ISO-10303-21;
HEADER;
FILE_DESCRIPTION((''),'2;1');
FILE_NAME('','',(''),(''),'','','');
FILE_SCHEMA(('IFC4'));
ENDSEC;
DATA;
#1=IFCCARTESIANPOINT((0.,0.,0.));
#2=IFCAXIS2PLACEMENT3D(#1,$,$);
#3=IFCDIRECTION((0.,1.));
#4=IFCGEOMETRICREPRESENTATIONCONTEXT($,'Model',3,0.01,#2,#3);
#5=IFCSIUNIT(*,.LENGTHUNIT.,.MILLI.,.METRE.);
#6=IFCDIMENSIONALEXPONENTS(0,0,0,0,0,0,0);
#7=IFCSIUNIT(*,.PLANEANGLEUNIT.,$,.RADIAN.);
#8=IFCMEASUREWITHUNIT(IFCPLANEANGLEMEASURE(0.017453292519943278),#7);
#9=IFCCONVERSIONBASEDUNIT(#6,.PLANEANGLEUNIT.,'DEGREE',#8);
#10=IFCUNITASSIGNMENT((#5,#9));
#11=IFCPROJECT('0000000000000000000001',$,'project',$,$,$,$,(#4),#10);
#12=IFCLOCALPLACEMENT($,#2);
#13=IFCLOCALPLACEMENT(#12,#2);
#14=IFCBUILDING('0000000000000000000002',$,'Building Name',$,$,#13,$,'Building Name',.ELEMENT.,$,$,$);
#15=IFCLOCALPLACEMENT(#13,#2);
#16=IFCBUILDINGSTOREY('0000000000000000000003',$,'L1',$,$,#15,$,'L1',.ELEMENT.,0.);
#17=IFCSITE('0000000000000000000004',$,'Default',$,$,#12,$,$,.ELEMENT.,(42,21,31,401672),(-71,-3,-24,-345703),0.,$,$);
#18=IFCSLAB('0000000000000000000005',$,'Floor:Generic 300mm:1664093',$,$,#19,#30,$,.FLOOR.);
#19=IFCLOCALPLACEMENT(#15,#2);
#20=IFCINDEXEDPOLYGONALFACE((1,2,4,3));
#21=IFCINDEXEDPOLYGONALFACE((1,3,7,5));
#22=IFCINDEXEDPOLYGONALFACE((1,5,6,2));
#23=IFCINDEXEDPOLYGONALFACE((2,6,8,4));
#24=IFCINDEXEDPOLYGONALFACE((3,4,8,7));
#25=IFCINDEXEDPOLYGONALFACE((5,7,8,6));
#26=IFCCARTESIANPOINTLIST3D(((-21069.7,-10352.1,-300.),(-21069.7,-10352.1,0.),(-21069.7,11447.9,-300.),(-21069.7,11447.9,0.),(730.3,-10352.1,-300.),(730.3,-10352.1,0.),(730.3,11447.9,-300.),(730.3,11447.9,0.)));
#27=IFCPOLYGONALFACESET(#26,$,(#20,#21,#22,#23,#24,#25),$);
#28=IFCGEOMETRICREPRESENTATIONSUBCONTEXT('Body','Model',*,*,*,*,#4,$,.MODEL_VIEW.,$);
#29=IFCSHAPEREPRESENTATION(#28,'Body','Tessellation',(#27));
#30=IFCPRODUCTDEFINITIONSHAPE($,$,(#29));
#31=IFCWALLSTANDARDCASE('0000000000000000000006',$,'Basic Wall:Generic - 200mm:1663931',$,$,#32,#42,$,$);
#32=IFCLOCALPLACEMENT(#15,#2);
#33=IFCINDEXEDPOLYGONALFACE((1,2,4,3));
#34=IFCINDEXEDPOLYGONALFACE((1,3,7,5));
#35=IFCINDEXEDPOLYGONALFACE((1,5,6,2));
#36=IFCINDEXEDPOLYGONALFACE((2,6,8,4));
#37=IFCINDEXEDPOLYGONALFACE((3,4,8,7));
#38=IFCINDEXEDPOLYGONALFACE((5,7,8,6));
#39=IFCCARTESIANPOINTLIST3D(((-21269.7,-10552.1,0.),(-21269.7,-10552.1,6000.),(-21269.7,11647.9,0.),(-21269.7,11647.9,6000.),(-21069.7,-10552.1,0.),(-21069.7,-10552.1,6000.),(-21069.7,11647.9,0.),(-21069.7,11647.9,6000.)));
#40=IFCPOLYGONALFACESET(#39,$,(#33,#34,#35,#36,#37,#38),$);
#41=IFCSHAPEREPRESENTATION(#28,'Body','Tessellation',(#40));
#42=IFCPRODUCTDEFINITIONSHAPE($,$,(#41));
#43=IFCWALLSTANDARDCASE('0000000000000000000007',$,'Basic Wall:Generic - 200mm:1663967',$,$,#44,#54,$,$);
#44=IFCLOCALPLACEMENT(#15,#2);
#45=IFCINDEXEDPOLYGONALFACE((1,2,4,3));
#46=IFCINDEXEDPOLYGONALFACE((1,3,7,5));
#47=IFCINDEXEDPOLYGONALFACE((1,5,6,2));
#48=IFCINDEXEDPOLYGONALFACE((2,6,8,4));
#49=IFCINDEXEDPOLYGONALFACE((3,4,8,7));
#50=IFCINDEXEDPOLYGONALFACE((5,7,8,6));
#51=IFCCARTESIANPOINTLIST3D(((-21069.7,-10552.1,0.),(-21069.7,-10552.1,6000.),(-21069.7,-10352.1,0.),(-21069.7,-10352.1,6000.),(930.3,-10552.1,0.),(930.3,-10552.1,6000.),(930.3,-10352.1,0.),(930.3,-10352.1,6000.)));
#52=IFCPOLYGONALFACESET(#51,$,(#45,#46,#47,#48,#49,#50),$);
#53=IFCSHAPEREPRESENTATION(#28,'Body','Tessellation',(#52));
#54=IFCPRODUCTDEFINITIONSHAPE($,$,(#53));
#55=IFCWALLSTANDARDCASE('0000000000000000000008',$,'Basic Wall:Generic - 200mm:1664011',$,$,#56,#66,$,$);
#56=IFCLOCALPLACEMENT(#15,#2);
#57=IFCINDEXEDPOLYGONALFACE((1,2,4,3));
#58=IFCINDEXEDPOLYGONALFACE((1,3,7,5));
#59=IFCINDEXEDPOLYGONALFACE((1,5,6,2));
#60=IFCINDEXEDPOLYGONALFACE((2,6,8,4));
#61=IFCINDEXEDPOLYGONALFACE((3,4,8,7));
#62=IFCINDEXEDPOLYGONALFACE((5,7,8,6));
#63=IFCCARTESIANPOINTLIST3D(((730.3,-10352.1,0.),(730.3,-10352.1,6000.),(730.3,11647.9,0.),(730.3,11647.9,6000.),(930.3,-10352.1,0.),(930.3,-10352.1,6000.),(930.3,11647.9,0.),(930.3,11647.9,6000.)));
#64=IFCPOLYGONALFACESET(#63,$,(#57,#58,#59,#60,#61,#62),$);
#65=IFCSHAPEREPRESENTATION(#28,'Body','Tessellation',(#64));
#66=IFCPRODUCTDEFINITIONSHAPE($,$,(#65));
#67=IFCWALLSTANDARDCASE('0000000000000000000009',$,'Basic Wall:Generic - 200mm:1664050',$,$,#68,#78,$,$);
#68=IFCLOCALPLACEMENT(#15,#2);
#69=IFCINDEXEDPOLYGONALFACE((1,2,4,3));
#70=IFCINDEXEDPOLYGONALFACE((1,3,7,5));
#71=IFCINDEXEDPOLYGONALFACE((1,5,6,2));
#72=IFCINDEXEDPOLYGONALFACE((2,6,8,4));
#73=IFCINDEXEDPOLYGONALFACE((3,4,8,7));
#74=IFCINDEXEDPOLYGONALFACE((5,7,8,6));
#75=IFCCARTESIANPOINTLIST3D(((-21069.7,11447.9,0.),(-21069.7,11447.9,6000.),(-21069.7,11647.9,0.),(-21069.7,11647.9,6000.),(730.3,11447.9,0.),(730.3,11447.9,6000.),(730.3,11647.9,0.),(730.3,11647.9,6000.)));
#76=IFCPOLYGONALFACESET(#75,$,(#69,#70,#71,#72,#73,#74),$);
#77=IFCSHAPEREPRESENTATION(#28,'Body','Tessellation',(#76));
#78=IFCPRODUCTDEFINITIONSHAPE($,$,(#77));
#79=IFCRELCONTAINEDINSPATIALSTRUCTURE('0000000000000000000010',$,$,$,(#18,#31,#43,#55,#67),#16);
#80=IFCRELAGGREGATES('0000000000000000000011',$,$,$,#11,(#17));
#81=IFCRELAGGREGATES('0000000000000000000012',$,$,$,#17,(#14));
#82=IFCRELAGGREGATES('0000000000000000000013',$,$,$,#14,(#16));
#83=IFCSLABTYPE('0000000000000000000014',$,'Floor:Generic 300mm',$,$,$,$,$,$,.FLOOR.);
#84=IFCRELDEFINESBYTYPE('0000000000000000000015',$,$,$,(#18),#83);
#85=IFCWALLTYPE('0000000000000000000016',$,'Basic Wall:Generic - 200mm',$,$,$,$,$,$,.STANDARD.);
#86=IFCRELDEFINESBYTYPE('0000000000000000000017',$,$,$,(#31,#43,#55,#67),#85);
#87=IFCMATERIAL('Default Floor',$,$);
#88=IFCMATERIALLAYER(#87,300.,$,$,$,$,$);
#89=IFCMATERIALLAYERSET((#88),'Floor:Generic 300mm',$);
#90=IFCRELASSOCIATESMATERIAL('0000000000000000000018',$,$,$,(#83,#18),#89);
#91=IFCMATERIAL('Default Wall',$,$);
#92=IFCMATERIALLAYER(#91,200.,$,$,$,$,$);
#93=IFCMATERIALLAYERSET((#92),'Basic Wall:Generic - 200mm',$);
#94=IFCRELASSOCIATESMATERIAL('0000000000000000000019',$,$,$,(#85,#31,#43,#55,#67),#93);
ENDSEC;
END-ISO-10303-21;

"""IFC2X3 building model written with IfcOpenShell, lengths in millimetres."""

from ifc_helpers import new_model, entity, si_unit, converted_unit, direction, frame, frame_2d, origin, origin_2d_with_axis, place, context, subcontext, project, spatial, rectangle, extrude, material, layer, layer_set, layer_usage, type_object, element, save


model = new_model("IFC2X3")

# Units and contexts
model_context = context("Model", 3, precision=0.01, world=origin(), true_north=direction((0.0, 1.0)))
body_context = subcontext(model_context, "Body", "Model", "MODEL_VIEW")
ifc_project = project(units=[si_unit("LENGTHUNIT", "METRE", prefix="MILLI"), converted_unit("PLANEANGLEUNIT", "DEGREE", entity("IfcPlaneAngleMeasure", 0.017453292519943278), si_unit("PLANEANGLEUNIT", "RADIAN"), dimensions=[0, 0, 0, 0, 0, 0, 0])], contexts=[model_context])

# Site, building, storey
site_placement = place(None, origin())
site = spatial("IfcSite", under=ifc_project, at=site_placement, Name="Default", CompositionType="ELEMENT", RefLatitude=(42, 21, 31, 401672), RefLongitude=(-71, -3, -24, -345703), RefElevation=0.0)
building_placement = place(site_placement, origin())
building = spatial("IfcBuilding", under=site, at=building_placement, Name="Building Name", LongName="Building Name", CompositionType="ELEMENT")
storey_placement = place(building_placement, origin())
storey = spatial("IfcBuildingStorey", under=building, at=storey_placement, Name="L1", LongName="L1", CompositionType="ELEMENT", Elevation=0.0)

# Slab
ifc_material_1 = material(Name="Default Floor")
ifc_layer_1 = layer(ifc_material_1, 300.0)
ifc_layer_set_1 = layer_set([ifc_layer_1], Name="Floor:Generic 300mm")
ifc_layer_usage_1 = layer_usage(ifc_layer_set_1, "AXIS3", "POSITIVE", 0.0)
slab_type = type_object("IfcSlabType", Name="Floor:Generic 300mm", PredefinedType="FLOOR", material=ifc_layer_set_1)
slab_placement = place(storey_placement, origin())
element("IfcSlab", 1, at=slab_placement, inside=storey, type_object=slab_type, material=ifc_layer_usage_1, Name="Floor:Generic 300mm:1664093", PredefinedType="FLOOR", context=body_context, shape_type="SweptSolid", body=[
    extrude(rectangle(XDim=21800.0, YDim=21800.0, at=origin_2d_with_axis()), frame((-10169.7, 547.9, 0.0), z_axis=(0.0, 0.0, -1.0), x_axis=(0.0, 1.0, 0.0)), (0.0, 0.0, 1.0), 300.0),
])

# Walls
ifc_material_2 = material(Name="Default Wall")
ifc_layer_2 = layer(ifc_material_2, 200.0)
ifc_layer_set_2 = layer_set([ifc_layer_2], Name="Basic Wall:Generic - 200mm")
ifc_layer_usage_2 = layer_usage(ifc_layer_set_2, "AXIS2", "NEGATIVE", 100.0)
wall_type = type_object("IfcWallType", Name="Basic Wall:Generic - 200mm", PredefinedType="STANDARD", material=ifc_layer_set_2)
wall_1_placement = place(storey_placement, frame((-21169.7, 11647.9, 0.0), z_axis=(0.0, 0.0, 1.0), x_axis=(0.0, -1.0, 0.0)))
element("IfcWallStandardCase", 2, at=wall_1_placement, inside=storey, type_object=wall_type, material=ifc_layer_usage_2, Name="Basic Wall:Generic - 200mm:1663931", context=body_context, shape_type="SweptSolid", body=[
    extrude(rectangle(XDim=22200.0, YDim=200.0, at=frame_2d((11100.0, 0.0), x_axis=(-1.0, 0.0))), origin(), (0.0, 0.0, 1.0), 6000.0),
])
ifc_layer_usage_3 = layer_usage(ifc_layer_set_2, "AXIS2", "NEGATIVE", 100.0)
wall_2_placement = place(storey_placement, frame((-21069.7, -10452.1, 0.0)))
element("IfcWallStandardCase", 3, at=wall_2_placement, inside=storey, type_object=wall_type, material=ifc_layer_usage_3, Name="Basic Wall:Generic - 200mm:1663967", context=body_context, shape_type="SweptSolid", body=[
    extrude(rectangle(XDim=22000.0, YDim=200.0, at=frame_2d((11000.0, 0.0), x_axis=(-1.0, 0.0))), origin(), (0.0, 0.0, 1.0), 6000.0),
])
ifc_layer_usage_4 = layer_usage(ifc_layer_set_2, "AXIS2", "NEGATIVE", 100.0)
wall_3_placement = place(storey_placement, frame((830.3, -10352.1, 0.0), z_axis=(0.0, 0.0, 1.0), x_axis=(0.0, 1.0, 0.0)))
element("IfcWallStandardCase", 4, at=wall_3_placement, inside=storey, type_object=wall_type, material=ifc_layer_usage_4, Name="Basic Wall:Generic - 200mm:1664011", context=body_context, shape_type="SweptSolid", body=[
    extrude(rectangle(XDim=22000.0, YDim=200.0, at=frame_2d((11000.0, 0.0), x_axis=(-1.0, 0.0))), origin(), (0.0, 0.0, 1.0), 6000.0),
])
ifc_layer_usage_5 = layer_usage(ifc_layer_set_2, "AXIS2", "NEGATIVE", 100.0)
wall_4_placement = place(storey_placement, frame((730.3, 11547.9, 0.0), z_axis=(0.0, 0.0, 1.0), x_axis=(-1.0, 0.0, 0.0)))
element("IfcWallStandardCase", 5, at=wall_4_placement, inside=storey, type_object=wall_type, material=ifc_layer_usage_5, Name="Basic Wall:Generic - 200mm:1664050", context=body_context, shape_type="SweptSolid", body=[
    extrude(rectangle(XDim=21800.0, YDim=200.0, at=frame_2d((10900.0, 0.0), x_axis=(-1.0, 0.0))), origin(), (0.0, 0.0, 1.0), 6000.0),
])

save(model, "model.ifc")
